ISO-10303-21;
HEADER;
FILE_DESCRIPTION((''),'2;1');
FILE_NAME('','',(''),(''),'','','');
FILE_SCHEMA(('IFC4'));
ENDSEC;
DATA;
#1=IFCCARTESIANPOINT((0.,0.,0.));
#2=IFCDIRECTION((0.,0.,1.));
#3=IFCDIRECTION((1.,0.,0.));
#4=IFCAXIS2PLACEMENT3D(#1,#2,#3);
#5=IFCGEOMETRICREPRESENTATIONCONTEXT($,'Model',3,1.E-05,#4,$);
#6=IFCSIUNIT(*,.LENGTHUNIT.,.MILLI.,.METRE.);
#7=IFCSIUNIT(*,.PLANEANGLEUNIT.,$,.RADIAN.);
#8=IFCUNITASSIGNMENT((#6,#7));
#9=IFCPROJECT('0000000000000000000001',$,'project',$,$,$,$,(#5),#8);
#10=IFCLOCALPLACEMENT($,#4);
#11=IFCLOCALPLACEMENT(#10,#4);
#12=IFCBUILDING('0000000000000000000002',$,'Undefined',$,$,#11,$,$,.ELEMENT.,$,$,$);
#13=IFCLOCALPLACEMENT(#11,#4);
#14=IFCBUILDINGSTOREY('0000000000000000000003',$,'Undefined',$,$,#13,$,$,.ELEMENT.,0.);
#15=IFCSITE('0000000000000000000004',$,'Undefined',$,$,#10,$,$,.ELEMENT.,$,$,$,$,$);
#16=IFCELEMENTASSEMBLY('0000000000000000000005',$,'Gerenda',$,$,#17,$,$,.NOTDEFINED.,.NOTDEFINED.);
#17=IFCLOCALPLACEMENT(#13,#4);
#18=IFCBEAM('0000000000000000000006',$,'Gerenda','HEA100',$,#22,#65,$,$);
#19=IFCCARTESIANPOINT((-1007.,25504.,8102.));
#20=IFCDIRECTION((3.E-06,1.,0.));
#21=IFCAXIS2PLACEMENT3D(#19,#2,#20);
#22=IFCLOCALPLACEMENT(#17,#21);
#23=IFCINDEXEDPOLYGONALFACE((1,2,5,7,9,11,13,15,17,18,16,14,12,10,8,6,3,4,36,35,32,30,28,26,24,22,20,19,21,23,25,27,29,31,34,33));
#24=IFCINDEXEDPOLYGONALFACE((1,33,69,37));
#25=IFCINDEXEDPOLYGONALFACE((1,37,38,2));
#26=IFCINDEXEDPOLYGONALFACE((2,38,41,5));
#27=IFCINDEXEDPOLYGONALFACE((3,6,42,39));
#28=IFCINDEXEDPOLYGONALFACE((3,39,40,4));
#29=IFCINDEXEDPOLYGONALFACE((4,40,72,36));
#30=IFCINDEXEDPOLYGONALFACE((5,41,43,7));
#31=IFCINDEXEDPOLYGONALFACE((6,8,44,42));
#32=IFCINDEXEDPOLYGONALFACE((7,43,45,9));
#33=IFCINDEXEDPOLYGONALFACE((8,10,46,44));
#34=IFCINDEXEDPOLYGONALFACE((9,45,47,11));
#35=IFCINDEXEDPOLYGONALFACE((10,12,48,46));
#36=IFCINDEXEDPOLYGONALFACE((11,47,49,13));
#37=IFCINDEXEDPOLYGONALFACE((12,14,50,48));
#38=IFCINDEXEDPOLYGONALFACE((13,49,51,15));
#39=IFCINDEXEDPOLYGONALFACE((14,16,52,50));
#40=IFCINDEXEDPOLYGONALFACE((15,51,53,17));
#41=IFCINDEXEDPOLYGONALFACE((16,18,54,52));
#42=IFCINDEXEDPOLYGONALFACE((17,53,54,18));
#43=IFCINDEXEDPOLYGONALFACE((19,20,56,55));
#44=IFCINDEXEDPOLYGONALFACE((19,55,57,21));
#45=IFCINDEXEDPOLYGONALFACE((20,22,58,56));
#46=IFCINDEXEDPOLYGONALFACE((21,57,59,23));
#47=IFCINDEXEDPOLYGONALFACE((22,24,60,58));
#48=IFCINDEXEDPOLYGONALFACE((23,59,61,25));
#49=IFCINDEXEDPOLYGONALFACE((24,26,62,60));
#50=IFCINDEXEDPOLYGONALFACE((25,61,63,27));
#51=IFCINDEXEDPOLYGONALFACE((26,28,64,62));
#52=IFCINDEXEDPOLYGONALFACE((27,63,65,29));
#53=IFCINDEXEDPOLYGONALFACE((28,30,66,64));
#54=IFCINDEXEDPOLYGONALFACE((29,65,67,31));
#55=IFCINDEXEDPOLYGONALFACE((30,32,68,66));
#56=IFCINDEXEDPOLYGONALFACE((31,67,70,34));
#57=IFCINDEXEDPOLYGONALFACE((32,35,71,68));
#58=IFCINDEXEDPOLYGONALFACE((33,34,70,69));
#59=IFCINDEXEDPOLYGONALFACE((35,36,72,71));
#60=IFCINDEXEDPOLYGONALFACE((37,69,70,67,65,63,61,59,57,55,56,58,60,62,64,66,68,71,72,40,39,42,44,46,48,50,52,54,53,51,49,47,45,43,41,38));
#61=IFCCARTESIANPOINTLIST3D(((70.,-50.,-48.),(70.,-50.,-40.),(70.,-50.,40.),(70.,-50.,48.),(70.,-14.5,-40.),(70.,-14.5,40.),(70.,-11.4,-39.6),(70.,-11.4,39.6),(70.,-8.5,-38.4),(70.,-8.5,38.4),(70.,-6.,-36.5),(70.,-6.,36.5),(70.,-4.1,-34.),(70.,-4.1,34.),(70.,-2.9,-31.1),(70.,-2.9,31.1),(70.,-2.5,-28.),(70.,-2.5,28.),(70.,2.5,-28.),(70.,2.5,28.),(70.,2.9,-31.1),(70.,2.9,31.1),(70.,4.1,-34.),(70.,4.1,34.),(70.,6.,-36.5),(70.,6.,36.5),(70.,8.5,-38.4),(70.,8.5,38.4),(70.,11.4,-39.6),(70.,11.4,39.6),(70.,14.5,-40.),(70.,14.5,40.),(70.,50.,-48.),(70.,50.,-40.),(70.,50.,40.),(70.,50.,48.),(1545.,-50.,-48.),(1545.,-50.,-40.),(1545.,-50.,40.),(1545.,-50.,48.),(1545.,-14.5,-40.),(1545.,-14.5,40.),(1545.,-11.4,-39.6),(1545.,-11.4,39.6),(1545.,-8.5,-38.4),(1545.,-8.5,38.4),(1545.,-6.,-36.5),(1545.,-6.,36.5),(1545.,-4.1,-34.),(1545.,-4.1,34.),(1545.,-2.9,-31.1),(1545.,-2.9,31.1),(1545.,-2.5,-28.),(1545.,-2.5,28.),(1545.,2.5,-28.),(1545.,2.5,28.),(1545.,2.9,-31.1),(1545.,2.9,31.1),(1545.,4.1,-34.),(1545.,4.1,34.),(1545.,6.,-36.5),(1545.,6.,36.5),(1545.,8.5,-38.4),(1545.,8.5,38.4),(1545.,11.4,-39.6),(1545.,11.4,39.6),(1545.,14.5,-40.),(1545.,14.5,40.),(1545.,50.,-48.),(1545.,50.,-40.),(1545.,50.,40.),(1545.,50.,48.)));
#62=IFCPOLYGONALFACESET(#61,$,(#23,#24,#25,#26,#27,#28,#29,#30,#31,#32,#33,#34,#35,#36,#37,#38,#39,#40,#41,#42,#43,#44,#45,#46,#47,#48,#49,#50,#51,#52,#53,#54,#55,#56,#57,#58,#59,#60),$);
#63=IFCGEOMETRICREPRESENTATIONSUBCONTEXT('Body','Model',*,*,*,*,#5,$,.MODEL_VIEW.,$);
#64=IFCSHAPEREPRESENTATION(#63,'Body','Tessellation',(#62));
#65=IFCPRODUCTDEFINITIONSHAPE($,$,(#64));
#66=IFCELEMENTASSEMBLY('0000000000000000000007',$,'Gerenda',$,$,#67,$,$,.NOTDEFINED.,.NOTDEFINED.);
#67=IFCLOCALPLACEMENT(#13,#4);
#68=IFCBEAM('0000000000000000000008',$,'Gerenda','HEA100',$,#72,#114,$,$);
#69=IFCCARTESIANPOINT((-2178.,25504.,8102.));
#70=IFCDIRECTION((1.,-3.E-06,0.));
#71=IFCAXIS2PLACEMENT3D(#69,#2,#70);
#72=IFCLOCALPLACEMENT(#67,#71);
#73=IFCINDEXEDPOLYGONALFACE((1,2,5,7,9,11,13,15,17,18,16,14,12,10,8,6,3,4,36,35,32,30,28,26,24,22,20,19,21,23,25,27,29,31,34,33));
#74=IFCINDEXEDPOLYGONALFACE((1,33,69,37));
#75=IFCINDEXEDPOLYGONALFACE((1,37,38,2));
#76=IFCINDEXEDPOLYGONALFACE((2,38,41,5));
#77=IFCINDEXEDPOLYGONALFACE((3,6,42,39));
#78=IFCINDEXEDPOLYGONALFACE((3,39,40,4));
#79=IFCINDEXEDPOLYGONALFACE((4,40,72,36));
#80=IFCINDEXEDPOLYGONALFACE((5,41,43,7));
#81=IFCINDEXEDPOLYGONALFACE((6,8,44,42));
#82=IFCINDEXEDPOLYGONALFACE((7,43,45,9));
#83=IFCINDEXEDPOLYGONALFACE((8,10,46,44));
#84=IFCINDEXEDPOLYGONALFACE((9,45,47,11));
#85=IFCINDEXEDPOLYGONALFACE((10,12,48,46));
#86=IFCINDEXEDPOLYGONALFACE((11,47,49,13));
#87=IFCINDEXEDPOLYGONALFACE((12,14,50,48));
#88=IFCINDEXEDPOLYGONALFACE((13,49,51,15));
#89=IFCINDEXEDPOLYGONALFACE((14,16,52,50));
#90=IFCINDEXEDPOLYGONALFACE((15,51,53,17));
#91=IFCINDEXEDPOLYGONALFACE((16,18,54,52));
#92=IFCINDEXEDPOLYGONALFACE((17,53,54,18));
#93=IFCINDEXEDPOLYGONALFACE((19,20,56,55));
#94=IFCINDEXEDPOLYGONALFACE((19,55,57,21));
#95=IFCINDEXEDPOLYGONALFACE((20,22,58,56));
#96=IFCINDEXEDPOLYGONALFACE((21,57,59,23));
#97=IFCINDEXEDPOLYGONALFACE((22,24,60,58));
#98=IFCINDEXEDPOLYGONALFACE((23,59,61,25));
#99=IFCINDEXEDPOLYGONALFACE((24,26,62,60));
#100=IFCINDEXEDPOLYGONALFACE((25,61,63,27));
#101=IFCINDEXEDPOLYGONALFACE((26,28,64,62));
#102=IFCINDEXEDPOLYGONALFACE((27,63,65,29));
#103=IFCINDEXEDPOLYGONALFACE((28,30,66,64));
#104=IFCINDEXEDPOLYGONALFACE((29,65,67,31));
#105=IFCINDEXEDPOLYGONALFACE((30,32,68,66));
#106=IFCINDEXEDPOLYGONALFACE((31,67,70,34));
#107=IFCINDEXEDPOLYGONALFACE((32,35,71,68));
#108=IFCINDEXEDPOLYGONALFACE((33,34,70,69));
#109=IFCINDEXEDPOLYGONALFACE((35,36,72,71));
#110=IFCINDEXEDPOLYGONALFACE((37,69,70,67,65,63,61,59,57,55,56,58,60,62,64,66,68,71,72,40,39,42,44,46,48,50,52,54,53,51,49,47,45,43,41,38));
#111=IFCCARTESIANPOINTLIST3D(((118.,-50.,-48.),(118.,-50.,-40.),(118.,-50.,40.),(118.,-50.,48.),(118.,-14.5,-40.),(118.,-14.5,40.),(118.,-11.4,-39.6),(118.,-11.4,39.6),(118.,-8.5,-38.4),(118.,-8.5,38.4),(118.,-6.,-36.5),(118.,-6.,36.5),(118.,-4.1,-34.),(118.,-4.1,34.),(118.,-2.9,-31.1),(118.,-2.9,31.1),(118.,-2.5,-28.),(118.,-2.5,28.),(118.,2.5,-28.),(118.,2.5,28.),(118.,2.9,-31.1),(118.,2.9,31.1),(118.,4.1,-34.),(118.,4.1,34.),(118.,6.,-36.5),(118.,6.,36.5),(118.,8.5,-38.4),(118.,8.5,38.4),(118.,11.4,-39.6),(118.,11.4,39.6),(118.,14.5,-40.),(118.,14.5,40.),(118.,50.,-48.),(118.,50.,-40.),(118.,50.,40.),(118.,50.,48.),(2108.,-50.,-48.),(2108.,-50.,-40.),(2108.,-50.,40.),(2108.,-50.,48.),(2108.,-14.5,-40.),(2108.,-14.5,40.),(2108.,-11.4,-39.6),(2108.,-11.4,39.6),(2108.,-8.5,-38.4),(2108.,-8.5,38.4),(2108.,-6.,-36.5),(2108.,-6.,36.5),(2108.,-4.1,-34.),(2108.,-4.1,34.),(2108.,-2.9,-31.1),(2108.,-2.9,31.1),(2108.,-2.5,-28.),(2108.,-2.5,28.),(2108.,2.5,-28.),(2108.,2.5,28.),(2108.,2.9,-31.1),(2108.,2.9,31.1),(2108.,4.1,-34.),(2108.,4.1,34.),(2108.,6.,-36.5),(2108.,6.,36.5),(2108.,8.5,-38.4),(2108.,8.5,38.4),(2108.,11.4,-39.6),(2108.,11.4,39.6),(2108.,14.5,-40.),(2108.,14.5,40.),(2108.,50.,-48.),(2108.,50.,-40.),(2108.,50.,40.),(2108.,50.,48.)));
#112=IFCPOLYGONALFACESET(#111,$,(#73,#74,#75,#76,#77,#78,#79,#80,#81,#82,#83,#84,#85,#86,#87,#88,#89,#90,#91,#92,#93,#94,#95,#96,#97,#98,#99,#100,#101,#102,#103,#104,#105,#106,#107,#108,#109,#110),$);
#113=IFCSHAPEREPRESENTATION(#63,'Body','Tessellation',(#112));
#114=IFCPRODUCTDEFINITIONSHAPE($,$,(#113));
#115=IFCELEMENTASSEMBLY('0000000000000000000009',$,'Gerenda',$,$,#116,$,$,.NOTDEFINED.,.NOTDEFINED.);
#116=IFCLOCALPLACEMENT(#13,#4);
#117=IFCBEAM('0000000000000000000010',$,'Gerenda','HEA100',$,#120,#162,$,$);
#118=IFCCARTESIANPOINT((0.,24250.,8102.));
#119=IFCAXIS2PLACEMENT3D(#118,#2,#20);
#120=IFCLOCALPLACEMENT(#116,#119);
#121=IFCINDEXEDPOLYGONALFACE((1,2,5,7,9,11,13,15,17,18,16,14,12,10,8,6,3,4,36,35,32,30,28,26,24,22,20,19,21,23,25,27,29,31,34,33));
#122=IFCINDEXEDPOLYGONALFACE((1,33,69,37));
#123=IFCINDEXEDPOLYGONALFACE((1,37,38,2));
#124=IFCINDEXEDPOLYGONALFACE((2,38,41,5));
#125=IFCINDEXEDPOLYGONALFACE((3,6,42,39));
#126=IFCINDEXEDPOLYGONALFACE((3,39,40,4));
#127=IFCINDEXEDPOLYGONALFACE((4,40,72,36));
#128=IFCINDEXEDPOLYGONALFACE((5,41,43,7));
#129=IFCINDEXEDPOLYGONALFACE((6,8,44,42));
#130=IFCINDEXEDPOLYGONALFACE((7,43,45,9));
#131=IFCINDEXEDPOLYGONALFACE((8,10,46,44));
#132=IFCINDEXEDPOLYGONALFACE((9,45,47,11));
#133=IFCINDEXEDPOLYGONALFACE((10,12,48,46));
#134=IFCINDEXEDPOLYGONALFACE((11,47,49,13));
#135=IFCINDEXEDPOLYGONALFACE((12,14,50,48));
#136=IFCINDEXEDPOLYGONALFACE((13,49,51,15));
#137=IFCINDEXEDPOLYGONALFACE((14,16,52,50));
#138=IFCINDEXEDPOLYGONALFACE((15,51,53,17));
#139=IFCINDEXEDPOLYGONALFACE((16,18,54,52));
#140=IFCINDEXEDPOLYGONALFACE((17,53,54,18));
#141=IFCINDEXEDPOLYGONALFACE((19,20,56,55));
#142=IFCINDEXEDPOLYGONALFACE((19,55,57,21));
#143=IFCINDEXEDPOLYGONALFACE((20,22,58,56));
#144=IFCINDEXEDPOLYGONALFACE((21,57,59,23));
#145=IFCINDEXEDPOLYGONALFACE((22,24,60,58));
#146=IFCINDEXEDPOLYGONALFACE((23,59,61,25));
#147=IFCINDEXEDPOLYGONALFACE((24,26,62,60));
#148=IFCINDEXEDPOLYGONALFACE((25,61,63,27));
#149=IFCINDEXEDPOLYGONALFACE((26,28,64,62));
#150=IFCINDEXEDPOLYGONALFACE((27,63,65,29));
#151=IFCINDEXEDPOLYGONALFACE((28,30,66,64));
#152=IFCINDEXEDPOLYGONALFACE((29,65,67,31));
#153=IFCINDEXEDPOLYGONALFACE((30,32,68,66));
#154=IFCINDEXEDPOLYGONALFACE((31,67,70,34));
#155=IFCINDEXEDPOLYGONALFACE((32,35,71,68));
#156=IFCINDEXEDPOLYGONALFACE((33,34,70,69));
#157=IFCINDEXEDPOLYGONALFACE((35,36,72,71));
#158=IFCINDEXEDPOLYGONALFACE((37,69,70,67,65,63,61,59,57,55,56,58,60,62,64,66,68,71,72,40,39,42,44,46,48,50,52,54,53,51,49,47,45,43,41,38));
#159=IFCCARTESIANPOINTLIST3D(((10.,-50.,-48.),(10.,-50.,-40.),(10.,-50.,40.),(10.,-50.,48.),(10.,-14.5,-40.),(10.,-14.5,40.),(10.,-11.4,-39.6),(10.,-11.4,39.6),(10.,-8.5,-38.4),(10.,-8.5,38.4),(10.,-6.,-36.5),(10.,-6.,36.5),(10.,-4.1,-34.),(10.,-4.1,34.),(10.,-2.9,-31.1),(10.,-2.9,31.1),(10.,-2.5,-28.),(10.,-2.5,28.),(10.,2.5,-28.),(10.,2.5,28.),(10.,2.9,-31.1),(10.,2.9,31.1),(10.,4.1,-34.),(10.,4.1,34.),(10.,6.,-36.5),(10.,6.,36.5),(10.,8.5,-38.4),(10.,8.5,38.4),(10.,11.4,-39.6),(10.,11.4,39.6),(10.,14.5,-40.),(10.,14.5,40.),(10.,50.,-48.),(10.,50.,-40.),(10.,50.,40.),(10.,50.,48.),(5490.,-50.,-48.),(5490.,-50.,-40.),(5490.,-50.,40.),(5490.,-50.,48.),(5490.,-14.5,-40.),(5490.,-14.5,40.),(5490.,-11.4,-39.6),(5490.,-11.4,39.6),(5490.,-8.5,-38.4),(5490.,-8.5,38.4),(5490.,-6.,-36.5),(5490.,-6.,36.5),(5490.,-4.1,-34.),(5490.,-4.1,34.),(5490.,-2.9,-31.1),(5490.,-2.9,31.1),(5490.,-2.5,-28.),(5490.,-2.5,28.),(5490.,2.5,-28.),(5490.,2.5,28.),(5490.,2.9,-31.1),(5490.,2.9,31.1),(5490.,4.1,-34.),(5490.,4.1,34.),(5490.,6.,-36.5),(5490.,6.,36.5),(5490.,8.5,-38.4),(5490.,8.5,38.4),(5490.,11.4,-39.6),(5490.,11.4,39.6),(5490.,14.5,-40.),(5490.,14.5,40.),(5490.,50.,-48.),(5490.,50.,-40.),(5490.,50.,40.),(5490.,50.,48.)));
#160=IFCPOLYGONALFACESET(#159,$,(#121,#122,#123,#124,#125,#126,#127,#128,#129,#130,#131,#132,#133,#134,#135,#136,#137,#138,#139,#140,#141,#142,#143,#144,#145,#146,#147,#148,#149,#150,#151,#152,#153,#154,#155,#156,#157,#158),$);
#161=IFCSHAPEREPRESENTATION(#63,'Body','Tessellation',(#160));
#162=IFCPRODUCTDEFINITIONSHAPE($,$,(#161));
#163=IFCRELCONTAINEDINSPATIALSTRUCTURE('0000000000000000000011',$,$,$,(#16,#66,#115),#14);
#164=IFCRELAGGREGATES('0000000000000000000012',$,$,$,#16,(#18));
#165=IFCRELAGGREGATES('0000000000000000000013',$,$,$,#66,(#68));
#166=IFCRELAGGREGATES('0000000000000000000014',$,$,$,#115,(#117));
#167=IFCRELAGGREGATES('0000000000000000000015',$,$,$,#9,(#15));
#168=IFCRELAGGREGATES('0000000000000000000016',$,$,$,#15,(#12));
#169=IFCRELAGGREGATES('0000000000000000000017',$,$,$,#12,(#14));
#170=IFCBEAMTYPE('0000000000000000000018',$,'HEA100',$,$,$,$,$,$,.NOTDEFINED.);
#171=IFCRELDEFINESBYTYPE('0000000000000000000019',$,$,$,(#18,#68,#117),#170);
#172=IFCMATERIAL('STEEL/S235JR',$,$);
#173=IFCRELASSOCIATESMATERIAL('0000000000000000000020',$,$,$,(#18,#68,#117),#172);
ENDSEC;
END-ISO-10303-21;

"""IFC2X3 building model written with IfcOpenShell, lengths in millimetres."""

from ifc_helpers import new_model, si_unit, frame, origin_with_axes, origin_2d_with_axis, place, context, subcontext, project, spatial, i_section, extrude, clip, halfspace, material, type_object, element, aggregate, save


model = new_model("IFC2X3")

# Units and contexts
model_context = context("Model", 3, precision=1e-05, world=origin_with_axes())
body_context = subcontext(model_context, "Body", "Model", "MODEL_VIEW")
ifc_project = project(units=[si_unit("LENGTHUNIT", "METRE", prefix="MILLI"), si_unit("PLANEANGLEUNIT", "RADIAN")], contexts=[model_context])

# Site, building, storey
site_placement = place(None, origin_with_axes())
site = spatial("IfcSite", under=ifc_project, at=site_placement, Name="Undefined", CompositionType="ELEMENT")
building_placement = place(site_placement, origin_with_axes())
building = spatial("IfcBuilding", under=site, at=building_placement, Name="Undefined", CompositionType="ELEMENT")
storey_placement = place(building_placement, origin_with_axes())
storey = spatial("IfcBuildingStorey", under=building, at=storey_placement, Name="Undefined", CompositionType="ELEMENT", Elevation=0.0)

# Element assemblies, beams
ifc_material_1 = material(Name="STEEL/S235JR")
beam_type_1 = type_object("IfcBeamType", Name="HEA100", PredefinedType="NOTDEFINED")
assembly_1_placement = place(storey_placement, origin_with_axes())
assembly_1 = element("IfcElementAssembly", 1, at=assembly_1_placement, inside=storey, Name="Gerenda", AssemblyPlace="NOTDEFINED", PredefinedType="NOTDEFINED")
beam_1_placement = place(assembly_1_placement, frame((-1007.0, 25504.0, 8102.0), z_axis=(0.0, 0.0, 1.0), x_axis=(0.000003, 1.0, 0.0)))
beam_1 = element("IfcBeam", 2, at=beam_1_placement, type_object=beam_type_1, material=ifc_material_1, Name="Gerenda", Description="HEA100", context=body_context, shape_type="Clipping", body=[
    clip(clip(extrude(i_section(OverallWidth=100.0, OverallDepth=96.0, WebThickness=5.0, FlangeThickness=8.0, FilletRadius=12.0, at=origin_2d_with_axis()), frame((1615.0, 0.0, 0.0), z_axis=(-1.0, 0.0, 0.0), x_axis=(0.0, -1.0, 0.0)), (0.0, 0.0, 1.0), 1615.0), halfspace(frame((1545.0, 0.0, -48.0), z_axis=(-1.0, 0.0, 0.0), x_axis=(0.0, 1.0, 0.0)), True)), halfspace(frame((70.0, 0.0, -48.0), z_axis=(1.0, 0.0, 0.0), x_axis=(0.0, -1.0, 0.0)), True)),
])
assembly_2_placement = place(storey_placement, origin_with_axes())
assembly_2 = element("IfcElementAssembly", 3, at=assembly_2_placement, inside=storey, Name="Gerenda", AssemblyPlace="NOTDEFINED", PredefinedType="NOTDEFINED")
beam_2_placement = place(assembly_2_placement, frame((-2178.0, 25504.0, 8102.0), z_axis=(0.0, 0.0, 1.0), x_axis=(1.0, -0.000003, 0.0)))
beam_2 = element("IfcBeam", 4, at=beam_2_placement, type_object=beam_type_1, material=ifc_material_1, Name="Gerenda", Description="HEA100", context=body_context, shape_type="Clipping", body=[
    clip(clip(extrude(i_section(OverallWidth=100.0, OverallDepth=96.0, WebThickness=5.0, FlangeThickness=8.0, FilletRadius=12.0, at=origin_2d_with_axis()), frame((2178.0, 0.0, 0.0), z_axis=(-1.0, 0.0, 0.0), x_axis=(0.0, -1.0, 0.0)), (0.0, 0.0, 1.0), 2178.0), halfspace(frame((2108.0, 0.0, -48.0), z_axis=(-1.0, 0.0, 0.0), x_axis=(0.0, 1.0, 0.0)), True)), halfspace(frame((118.0, 0.0, -48.0), z_axis=(1.0, -0.000002, 0.0), x_axis=(-0.000002, -1.0, 0.0)), True)),
])
assembly_3_placement = place(storey_placement, origin_with_axes())
assembly_3 = element("IfcElementAssembly", 5, at=assembly_3_placement, inside=storey, Name="Gerenda", AssemblyPlace="NOTDEFINED", PredefinedType="NOTDEFINED")
beam_3_placement = place(assembly_3_placement, frame((0.0, 24250.0, 8102.0), z_axis=(0.0, 0.0, 1.0), x_axis=(0.000003, 1.0, 0.0)))
beam_3 = element("IfcBeam", 6, at=beam_3_placement, type_object=beam_type_1, material=ifc_material_1, Name="Gerenda", Description="HEA100", context=body_context, shape_type="Clipping", body=[
    clip(clip(extrude(i_section(OverallWidth=100.0, OverallDepth=96.0, WebThickness=5.0, FlangeThickness=8.0, FilletRadius=12.0, at=origin_2d_with_axis()), frame((5500.0, 0.0, 0.0), z_axis=(-1.0, 0.0, 0.0), x_axis=(0.0, -1.0, 0.0)), (0.0, 0.0, 1.0), 5500.0), halfspace(frame((5490.0, 0.0, -48.0), z_axis=(-1.0, 0.0, 0.0), x_axis=(0.0, 1.0, 0.0)), True)), halfspace(frame((10.0, 0.0, -48.0), z_axis=(1.0, 0.0, 0.0), x_axis=(0.0, -1.0, 0.0)), True)),
])

aggregate(assembly_1, [beam_1])
aggregate(assembly_2, [beam_2])
aggregate(assembly_3, [beam_3])

save(model, "model.ifc")
